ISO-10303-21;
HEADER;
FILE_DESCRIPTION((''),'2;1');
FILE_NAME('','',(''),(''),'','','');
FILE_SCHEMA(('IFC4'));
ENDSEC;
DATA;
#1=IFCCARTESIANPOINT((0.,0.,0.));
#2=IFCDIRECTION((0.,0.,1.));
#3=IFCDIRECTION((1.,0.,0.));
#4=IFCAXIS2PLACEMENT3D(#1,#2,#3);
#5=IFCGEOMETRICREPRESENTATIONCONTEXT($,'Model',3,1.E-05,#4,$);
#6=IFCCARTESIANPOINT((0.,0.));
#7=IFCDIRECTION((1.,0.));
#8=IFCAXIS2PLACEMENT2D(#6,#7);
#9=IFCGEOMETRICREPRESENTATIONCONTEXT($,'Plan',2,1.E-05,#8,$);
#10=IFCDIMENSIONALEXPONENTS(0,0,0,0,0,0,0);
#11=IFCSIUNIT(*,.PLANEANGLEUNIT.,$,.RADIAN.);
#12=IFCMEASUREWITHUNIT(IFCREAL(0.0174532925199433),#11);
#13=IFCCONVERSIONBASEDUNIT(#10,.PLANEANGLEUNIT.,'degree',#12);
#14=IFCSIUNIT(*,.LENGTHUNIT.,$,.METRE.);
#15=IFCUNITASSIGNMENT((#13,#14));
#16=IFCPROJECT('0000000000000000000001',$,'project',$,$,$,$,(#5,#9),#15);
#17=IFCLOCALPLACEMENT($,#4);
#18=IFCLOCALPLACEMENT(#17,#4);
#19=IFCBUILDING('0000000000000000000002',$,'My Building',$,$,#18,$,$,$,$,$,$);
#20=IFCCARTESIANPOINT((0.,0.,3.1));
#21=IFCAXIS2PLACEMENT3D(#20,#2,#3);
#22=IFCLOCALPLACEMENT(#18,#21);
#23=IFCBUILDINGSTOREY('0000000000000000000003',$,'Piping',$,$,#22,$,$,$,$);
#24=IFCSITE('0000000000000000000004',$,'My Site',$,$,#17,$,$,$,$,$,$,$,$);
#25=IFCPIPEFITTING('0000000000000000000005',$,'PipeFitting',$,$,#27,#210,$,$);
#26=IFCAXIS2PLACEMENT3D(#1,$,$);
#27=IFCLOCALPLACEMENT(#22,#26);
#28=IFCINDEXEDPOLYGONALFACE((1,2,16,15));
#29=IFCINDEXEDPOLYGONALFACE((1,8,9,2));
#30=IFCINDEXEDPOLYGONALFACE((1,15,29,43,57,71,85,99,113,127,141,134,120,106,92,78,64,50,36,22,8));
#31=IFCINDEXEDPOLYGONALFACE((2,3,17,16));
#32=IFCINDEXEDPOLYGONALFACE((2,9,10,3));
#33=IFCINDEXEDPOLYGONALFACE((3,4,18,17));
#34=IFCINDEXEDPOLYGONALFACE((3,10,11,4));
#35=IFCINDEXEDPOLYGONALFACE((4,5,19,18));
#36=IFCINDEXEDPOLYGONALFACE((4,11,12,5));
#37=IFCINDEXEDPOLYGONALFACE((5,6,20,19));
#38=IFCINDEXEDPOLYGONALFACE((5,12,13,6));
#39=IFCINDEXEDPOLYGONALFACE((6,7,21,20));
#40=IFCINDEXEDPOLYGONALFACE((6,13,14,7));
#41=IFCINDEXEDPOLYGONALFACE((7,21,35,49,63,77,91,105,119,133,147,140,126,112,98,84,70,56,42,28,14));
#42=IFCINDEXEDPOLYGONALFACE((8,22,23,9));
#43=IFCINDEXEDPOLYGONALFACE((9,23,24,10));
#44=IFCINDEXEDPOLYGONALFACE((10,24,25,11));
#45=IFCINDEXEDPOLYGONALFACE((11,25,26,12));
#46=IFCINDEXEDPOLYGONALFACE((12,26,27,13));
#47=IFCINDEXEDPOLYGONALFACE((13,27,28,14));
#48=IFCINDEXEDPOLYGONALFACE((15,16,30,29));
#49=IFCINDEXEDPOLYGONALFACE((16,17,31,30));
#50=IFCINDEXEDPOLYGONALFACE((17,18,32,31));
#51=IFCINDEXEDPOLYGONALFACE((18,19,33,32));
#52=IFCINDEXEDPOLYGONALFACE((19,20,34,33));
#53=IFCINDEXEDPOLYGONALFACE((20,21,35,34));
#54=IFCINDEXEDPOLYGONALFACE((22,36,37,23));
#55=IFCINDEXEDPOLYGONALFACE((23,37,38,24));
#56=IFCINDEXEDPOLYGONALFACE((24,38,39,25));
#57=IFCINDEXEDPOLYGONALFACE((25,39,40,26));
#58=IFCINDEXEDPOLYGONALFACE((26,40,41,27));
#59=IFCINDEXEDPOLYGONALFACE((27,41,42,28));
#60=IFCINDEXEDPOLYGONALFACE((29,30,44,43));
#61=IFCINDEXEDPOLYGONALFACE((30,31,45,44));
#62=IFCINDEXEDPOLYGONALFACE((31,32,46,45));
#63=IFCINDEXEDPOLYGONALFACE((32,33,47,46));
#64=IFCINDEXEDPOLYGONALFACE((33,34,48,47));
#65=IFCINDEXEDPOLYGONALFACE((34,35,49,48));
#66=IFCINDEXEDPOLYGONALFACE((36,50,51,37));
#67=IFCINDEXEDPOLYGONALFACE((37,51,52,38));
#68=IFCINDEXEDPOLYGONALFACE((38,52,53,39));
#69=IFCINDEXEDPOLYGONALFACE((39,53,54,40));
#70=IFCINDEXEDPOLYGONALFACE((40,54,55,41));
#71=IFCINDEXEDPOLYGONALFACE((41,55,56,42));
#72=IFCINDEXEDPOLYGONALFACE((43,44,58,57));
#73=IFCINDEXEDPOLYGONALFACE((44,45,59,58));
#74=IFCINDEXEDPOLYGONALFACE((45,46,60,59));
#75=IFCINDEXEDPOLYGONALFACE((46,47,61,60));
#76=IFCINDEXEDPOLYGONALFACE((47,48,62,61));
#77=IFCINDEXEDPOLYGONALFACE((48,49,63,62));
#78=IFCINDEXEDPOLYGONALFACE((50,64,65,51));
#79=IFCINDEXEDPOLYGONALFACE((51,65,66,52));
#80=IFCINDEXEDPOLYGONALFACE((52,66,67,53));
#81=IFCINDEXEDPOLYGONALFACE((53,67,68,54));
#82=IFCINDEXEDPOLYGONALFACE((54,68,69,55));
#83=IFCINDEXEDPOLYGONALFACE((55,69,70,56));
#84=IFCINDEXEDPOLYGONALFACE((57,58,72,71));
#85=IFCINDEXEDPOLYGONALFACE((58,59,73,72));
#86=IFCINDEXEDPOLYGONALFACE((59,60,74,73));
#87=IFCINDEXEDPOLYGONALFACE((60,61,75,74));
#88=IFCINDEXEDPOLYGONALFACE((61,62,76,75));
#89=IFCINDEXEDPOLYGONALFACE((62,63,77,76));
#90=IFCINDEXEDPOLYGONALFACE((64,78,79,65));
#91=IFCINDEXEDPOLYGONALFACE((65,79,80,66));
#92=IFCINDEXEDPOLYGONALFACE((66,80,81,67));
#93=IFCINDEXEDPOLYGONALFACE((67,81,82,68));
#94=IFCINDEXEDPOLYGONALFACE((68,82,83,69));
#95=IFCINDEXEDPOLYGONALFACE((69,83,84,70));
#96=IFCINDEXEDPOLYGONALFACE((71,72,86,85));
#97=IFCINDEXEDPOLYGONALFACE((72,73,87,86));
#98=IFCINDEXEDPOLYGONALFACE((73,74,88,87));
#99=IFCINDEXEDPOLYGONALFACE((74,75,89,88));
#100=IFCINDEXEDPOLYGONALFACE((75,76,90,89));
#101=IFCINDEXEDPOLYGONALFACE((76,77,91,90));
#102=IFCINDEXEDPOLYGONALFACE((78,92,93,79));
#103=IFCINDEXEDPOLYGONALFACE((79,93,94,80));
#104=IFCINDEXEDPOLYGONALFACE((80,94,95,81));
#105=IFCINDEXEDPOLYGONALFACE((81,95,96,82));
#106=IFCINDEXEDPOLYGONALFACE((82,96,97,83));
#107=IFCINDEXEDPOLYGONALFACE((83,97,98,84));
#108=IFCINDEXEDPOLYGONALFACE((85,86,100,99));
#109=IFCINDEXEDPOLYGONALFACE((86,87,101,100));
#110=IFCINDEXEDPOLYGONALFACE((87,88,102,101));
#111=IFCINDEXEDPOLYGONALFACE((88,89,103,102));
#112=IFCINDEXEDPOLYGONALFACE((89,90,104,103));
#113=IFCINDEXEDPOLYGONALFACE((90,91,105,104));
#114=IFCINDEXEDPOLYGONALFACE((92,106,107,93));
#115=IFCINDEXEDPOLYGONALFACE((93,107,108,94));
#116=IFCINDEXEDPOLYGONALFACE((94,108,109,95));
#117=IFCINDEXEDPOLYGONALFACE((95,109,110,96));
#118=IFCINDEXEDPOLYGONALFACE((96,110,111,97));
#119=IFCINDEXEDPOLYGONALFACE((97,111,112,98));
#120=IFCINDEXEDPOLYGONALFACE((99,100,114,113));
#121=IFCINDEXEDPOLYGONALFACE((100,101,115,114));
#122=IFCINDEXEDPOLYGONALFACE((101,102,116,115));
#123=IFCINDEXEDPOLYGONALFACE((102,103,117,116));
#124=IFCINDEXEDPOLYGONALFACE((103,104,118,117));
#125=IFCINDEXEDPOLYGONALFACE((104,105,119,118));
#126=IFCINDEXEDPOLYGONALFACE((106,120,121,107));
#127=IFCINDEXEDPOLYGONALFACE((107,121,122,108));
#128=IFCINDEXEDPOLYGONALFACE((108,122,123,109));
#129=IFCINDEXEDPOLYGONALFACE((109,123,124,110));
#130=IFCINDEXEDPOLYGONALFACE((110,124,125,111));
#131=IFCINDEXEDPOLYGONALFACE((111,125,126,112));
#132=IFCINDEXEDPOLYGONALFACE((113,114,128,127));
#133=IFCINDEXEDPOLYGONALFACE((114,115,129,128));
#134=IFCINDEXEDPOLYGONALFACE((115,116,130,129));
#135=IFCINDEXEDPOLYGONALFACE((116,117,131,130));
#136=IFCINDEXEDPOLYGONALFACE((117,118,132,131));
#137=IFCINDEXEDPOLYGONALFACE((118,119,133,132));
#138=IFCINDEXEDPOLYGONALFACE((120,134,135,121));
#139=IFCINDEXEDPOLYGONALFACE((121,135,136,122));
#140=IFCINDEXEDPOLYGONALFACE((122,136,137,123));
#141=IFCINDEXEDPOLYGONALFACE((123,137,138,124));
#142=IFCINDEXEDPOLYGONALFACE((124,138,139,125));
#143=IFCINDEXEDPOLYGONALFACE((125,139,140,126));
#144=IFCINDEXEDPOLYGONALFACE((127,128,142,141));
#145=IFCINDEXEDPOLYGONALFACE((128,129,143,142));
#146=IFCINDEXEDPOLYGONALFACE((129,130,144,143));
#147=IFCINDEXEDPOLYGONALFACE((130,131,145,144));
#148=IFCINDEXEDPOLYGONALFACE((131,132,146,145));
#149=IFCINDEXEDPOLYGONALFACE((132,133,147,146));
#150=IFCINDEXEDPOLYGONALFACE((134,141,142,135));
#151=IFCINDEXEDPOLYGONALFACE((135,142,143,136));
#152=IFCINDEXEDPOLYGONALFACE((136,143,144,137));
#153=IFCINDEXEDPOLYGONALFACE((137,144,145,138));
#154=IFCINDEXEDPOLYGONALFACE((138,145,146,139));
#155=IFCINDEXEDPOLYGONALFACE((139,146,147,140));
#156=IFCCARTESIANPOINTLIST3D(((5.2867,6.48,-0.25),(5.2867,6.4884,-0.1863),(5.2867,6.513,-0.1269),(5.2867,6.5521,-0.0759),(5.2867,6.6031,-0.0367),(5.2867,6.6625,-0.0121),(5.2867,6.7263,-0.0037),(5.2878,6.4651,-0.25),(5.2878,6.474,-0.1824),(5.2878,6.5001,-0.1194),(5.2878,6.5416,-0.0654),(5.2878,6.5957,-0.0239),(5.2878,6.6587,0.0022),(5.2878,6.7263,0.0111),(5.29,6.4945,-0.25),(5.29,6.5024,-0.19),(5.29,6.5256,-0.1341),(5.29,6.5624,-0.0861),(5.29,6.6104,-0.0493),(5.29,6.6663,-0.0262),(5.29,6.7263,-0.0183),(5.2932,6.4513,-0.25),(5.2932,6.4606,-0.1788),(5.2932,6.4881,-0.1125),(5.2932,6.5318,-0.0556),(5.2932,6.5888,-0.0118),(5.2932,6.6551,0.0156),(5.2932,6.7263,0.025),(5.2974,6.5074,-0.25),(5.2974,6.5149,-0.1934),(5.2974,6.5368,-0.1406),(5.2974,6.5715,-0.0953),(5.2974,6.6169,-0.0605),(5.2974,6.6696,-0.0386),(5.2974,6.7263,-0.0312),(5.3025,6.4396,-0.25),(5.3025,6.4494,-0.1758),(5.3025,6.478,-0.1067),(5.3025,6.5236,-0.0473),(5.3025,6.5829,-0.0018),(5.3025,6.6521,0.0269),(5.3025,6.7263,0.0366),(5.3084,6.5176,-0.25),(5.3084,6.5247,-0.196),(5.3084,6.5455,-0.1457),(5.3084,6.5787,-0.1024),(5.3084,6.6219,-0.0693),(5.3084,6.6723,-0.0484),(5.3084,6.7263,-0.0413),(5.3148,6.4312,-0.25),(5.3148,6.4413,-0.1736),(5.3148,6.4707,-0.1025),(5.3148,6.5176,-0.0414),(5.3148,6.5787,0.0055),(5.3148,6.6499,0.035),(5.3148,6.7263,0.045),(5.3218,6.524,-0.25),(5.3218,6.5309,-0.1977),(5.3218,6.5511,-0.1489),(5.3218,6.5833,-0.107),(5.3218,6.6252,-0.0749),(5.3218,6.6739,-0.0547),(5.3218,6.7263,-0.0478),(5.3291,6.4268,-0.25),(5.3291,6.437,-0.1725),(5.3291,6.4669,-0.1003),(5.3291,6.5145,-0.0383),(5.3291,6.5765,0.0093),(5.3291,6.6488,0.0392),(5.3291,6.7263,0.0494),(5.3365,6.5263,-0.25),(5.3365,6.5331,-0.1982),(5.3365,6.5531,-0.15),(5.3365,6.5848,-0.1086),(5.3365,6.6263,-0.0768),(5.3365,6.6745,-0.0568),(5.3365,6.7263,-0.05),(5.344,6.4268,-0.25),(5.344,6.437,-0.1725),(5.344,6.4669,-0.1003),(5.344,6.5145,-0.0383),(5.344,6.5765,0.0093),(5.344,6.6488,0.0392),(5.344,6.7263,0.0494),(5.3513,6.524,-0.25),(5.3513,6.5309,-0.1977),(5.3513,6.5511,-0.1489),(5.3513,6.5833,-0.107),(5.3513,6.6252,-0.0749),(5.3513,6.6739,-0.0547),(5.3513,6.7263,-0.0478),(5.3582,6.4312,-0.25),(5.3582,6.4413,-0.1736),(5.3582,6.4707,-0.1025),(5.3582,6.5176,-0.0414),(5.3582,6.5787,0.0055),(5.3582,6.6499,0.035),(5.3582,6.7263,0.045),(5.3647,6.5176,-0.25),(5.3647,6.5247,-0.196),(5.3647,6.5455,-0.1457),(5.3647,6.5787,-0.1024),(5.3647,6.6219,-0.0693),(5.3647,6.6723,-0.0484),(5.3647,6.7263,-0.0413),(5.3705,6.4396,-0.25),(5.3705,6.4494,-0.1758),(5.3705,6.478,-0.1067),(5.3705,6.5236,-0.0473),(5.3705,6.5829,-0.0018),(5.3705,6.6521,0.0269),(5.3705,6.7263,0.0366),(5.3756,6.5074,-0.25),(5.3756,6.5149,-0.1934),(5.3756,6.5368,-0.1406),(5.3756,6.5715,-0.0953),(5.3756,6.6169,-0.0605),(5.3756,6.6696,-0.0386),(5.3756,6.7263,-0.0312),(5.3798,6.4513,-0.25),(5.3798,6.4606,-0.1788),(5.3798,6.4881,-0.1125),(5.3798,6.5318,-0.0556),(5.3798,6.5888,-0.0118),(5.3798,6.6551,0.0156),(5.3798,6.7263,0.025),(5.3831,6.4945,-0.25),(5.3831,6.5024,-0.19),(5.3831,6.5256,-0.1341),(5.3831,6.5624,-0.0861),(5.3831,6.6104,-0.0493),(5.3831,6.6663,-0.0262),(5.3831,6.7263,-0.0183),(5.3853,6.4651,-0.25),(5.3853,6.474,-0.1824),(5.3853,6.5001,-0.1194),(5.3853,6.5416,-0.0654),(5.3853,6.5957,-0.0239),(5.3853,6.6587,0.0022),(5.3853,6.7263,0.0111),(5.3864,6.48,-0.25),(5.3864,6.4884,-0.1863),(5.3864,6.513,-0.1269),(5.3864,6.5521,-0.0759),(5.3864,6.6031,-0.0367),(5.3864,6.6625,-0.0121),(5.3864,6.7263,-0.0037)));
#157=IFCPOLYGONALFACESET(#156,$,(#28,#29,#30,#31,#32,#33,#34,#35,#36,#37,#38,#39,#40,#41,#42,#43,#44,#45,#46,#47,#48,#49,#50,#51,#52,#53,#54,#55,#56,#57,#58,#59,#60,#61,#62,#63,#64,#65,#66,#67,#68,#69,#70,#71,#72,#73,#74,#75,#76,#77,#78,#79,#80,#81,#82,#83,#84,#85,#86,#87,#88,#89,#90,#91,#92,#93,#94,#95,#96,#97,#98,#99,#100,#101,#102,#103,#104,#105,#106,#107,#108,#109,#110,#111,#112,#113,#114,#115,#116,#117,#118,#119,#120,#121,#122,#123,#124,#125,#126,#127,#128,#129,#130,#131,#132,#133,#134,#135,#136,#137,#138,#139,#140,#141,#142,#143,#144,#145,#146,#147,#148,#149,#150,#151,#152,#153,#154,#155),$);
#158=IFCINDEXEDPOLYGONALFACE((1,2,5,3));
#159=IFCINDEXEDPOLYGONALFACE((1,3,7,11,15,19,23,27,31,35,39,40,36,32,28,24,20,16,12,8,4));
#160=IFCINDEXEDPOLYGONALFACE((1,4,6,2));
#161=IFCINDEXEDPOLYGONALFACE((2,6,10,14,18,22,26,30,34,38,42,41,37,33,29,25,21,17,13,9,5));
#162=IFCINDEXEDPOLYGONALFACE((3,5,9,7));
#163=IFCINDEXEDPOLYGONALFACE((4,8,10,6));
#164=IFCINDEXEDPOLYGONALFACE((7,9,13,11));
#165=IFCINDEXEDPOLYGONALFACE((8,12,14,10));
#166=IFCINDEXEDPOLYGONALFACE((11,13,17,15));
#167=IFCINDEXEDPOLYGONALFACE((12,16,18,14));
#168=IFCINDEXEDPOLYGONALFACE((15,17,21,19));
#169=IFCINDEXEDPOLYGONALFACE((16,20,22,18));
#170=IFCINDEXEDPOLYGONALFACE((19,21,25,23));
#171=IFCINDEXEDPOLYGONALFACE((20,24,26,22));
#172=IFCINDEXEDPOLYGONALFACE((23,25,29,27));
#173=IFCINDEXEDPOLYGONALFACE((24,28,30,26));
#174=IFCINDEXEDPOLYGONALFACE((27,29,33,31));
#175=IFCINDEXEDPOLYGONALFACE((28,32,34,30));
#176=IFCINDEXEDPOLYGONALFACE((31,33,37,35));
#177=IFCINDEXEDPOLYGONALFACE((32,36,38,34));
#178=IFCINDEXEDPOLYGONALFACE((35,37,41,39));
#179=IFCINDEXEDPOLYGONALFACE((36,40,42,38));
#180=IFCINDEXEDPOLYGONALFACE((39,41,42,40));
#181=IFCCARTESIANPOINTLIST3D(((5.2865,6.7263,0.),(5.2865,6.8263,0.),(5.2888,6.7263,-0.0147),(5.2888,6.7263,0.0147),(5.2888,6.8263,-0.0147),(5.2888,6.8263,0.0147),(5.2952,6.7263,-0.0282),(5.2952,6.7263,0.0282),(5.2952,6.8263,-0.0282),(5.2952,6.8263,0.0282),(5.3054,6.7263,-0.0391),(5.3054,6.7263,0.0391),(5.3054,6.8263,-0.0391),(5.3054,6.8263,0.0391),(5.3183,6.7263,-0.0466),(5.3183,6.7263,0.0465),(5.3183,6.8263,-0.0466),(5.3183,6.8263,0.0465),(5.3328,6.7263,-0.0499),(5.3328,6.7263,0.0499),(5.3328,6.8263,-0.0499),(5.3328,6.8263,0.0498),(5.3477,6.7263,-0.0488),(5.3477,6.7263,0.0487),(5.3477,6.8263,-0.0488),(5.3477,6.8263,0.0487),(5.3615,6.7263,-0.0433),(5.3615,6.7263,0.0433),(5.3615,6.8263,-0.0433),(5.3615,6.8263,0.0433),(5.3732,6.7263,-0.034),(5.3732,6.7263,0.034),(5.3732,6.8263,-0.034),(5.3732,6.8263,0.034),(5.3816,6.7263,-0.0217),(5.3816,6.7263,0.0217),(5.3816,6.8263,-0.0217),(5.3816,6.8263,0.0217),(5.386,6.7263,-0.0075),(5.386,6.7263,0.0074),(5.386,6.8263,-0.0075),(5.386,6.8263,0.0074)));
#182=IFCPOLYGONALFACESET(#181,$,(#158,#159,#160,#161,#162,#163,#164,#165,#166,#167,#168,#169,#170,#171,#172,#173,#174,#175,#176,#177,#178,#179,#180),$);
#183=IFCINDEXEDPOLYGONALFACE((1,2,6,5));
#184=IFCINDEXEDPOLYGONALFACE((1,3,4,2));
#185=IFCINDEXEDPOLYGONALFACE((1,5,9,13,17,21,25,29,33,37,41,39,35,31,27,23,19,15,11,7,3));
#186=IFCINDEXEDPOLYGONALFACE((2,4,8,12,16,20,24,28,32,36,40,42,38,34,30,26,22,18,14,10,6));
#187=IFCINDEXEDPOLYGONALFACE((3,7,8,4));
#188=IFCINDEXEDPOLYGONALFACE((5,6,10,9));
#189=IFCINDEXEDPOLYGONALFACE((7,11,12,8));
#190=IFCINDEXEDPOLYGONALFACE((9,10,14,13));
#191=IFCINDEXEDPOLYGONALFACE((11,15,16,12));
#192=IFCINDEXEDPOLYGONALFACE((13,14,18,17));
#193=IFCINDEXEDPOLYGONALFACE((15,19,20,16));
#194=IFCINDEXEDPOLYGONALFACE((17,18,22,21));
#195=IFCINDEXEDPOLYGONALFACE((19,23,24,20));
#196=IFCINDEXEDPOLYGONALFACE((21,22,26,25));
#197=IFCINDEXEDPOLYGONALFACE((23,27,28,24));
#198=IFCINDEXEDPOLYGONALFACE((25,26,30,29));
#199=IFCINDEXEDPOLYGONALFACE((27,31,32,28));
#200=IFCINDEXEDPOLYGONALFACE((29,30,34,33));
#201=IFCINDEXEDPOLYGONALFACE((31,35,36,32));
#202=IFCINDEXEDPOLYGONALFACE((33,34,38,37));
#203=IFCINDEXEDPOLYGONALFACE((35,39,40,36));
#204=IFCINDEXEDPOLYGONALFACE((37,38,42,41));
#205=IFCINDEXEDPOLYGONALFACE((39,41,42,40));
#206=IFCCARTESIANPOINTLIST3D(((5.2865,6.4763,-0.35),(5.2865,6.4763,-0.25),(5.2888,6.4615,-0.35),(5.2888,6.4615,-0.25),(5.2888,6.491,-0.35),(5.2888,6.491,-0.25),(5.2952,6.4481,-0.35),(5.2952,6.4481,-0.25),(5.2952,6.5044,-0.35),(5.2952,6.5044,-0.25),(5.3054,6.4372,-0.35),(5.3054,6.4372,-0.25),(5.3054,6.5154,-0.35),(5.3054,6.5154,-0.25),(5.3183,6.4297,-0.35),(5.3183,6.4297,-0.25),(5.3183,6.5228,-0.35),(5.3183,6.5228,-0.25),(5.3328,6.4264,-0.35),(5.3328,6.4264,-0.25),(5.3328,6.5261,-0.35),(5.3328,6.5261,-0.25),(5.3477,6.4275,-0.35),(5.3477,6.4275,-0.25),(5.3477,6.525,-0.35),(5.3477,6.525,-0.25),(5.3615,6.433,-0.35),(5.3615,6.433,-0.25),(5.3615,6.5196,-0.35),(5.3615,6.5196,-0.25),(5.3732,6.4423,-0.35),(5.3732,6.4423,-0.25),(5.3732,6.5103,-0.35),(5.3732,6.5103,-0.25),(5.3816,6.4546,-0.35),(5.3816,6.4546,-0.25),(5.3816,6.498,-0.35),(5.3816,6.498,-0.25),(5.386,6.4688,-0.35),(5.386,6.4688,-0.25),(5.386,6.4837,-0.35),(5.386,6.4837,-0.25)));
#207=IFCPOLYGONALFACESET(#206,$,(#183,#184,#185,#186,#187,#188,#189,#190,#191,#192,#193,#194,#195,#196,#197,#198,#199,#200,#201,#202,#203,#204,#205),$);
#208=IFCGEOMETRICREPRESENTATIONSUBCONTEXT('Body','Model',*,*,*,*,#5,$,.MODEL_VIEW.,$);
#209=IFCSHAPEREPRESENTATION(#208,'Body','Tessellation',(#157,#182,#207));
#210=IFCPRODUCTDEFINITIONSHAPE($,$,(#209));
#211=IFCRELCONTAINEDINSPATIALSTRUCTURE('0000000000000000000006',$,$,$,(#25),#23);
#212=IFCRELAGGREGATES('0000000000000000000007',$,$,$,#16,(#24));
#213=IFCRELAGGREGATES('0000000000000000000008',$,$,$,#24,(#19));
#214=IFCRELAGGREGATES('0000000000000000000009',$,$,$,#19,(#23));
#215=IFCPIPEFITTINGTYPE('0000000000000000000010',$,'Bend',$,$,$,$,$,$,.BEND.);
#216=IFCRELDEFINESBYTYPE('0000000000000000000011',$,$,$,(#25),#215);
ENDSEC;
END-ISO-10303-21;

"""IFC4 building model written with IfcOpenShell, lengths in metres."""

from ifc_helpers import new_model, entity, si_unit, converted_unit, frame, origin_with_axes, origin_2d_with_axis, place, context, subcontext, project, spatial, circle, extrude, source, transform, mapped, type_object, type_shapes, element, save


model = new_model("IFC4")

# Units and contexts
model_context = context("Model", 3, precision=1e-05, world=origin_with_axes())
plan_context = context("Plan", 2, precision=1e-05, world=origin_2d_with_axis())
body_context = subcontext(model_context, "Body", "Model", "MODEL_VIEW")
ifc_project = project(units=[converted_unit("PLANEANGLEUNIT", "degree", entity("IfcReal", 0.0174532925199433), si_unit("PLANEANGLEUNIT", "RADIAN"), dimensions=[0, 0, 0, 0, 0, 0, 0]), si_unit("LENGTHUNIT", "METRE")], contexts=[model_context, plan_context])

# Site, building, storey
site_placement = place(None, origin_with_axes())
site = spatial("IfcSite", under=ifc_project, at=site_placement, Name="My Site")
building_placement = place(site_placement, origin_with_axes())
building = spatial("IfcBuilding", under=site, at=building_placement, Name="My Building")
storey_placement = place(building_placement, frame((0.0, 0.0, 3.1), z_axis=(0.0, 0.0, 1.0), x_axis=(1.0, 0.0, 0.0)))
storey = spatial("IfcBuildingStorey", under=building, at=storey_placement, Name="Piping")

# Pipe fitting
pipe_fitting_type_1 = type_object("IfcPipeFittingType", Name="Bend", PredefinedType="BEND")
shared_shape_1 = source(origin_with_axes(), body_context, "Body", "SolidModel", [
    entity("IfcSweptDiskSolid", entity("IfcIndexedPolyCurve", entity("IfcCartesianPointList3D", [[0.0, 0.0, -0.1], [0.0, -0.0732, -0.2768], [0.0, -0.25, -0.35]]), [entity("IfcArcIndex", [1, 2, 3])]), 0.05),
    extrude(circle(Radius=0.05), origin_with_axes(), (0.0, 0.0, -1.0), 0.1),
    extrude(circle(Radius=0.05), frame((0.0, -0.25, -0.35), z_axis=(0.0, -1.0, 0.000022), x_axis=(1.0, 0.0, 0.0)), (0.0, 0.0, 1.0), 0.1),
])
type_shapes(pipe_fitting_type_1, [shared_shape_1])
for number, where, z_axis, x_axis, name in (
    (1, (5.3365, 6.8263, 0.0), (0.0, 1.0, -0.000022), (-1.0, 0.0, 0.0), "PipeFitting"),
):
    element("IfcPipeFitting", number, at=place(storey_placement, frame(where, z_axis=z_axis, x_axis=x_axis)), inside=storey, type_object=pipe_fitting_type_1, Name=name, context=body_context, shape_type="MappedRepresentation", body=[
        mapped(shared_shape_1, transform((0.0, 0.0, 0.0), x_axis=(1.0, 0.0, 0.0), y_axis=(0.0, 1.0, 0.0), z_axis=(0.0, 0.0, 1.0), scale=1.0)),
    ])

save(model, "model.ifc")
